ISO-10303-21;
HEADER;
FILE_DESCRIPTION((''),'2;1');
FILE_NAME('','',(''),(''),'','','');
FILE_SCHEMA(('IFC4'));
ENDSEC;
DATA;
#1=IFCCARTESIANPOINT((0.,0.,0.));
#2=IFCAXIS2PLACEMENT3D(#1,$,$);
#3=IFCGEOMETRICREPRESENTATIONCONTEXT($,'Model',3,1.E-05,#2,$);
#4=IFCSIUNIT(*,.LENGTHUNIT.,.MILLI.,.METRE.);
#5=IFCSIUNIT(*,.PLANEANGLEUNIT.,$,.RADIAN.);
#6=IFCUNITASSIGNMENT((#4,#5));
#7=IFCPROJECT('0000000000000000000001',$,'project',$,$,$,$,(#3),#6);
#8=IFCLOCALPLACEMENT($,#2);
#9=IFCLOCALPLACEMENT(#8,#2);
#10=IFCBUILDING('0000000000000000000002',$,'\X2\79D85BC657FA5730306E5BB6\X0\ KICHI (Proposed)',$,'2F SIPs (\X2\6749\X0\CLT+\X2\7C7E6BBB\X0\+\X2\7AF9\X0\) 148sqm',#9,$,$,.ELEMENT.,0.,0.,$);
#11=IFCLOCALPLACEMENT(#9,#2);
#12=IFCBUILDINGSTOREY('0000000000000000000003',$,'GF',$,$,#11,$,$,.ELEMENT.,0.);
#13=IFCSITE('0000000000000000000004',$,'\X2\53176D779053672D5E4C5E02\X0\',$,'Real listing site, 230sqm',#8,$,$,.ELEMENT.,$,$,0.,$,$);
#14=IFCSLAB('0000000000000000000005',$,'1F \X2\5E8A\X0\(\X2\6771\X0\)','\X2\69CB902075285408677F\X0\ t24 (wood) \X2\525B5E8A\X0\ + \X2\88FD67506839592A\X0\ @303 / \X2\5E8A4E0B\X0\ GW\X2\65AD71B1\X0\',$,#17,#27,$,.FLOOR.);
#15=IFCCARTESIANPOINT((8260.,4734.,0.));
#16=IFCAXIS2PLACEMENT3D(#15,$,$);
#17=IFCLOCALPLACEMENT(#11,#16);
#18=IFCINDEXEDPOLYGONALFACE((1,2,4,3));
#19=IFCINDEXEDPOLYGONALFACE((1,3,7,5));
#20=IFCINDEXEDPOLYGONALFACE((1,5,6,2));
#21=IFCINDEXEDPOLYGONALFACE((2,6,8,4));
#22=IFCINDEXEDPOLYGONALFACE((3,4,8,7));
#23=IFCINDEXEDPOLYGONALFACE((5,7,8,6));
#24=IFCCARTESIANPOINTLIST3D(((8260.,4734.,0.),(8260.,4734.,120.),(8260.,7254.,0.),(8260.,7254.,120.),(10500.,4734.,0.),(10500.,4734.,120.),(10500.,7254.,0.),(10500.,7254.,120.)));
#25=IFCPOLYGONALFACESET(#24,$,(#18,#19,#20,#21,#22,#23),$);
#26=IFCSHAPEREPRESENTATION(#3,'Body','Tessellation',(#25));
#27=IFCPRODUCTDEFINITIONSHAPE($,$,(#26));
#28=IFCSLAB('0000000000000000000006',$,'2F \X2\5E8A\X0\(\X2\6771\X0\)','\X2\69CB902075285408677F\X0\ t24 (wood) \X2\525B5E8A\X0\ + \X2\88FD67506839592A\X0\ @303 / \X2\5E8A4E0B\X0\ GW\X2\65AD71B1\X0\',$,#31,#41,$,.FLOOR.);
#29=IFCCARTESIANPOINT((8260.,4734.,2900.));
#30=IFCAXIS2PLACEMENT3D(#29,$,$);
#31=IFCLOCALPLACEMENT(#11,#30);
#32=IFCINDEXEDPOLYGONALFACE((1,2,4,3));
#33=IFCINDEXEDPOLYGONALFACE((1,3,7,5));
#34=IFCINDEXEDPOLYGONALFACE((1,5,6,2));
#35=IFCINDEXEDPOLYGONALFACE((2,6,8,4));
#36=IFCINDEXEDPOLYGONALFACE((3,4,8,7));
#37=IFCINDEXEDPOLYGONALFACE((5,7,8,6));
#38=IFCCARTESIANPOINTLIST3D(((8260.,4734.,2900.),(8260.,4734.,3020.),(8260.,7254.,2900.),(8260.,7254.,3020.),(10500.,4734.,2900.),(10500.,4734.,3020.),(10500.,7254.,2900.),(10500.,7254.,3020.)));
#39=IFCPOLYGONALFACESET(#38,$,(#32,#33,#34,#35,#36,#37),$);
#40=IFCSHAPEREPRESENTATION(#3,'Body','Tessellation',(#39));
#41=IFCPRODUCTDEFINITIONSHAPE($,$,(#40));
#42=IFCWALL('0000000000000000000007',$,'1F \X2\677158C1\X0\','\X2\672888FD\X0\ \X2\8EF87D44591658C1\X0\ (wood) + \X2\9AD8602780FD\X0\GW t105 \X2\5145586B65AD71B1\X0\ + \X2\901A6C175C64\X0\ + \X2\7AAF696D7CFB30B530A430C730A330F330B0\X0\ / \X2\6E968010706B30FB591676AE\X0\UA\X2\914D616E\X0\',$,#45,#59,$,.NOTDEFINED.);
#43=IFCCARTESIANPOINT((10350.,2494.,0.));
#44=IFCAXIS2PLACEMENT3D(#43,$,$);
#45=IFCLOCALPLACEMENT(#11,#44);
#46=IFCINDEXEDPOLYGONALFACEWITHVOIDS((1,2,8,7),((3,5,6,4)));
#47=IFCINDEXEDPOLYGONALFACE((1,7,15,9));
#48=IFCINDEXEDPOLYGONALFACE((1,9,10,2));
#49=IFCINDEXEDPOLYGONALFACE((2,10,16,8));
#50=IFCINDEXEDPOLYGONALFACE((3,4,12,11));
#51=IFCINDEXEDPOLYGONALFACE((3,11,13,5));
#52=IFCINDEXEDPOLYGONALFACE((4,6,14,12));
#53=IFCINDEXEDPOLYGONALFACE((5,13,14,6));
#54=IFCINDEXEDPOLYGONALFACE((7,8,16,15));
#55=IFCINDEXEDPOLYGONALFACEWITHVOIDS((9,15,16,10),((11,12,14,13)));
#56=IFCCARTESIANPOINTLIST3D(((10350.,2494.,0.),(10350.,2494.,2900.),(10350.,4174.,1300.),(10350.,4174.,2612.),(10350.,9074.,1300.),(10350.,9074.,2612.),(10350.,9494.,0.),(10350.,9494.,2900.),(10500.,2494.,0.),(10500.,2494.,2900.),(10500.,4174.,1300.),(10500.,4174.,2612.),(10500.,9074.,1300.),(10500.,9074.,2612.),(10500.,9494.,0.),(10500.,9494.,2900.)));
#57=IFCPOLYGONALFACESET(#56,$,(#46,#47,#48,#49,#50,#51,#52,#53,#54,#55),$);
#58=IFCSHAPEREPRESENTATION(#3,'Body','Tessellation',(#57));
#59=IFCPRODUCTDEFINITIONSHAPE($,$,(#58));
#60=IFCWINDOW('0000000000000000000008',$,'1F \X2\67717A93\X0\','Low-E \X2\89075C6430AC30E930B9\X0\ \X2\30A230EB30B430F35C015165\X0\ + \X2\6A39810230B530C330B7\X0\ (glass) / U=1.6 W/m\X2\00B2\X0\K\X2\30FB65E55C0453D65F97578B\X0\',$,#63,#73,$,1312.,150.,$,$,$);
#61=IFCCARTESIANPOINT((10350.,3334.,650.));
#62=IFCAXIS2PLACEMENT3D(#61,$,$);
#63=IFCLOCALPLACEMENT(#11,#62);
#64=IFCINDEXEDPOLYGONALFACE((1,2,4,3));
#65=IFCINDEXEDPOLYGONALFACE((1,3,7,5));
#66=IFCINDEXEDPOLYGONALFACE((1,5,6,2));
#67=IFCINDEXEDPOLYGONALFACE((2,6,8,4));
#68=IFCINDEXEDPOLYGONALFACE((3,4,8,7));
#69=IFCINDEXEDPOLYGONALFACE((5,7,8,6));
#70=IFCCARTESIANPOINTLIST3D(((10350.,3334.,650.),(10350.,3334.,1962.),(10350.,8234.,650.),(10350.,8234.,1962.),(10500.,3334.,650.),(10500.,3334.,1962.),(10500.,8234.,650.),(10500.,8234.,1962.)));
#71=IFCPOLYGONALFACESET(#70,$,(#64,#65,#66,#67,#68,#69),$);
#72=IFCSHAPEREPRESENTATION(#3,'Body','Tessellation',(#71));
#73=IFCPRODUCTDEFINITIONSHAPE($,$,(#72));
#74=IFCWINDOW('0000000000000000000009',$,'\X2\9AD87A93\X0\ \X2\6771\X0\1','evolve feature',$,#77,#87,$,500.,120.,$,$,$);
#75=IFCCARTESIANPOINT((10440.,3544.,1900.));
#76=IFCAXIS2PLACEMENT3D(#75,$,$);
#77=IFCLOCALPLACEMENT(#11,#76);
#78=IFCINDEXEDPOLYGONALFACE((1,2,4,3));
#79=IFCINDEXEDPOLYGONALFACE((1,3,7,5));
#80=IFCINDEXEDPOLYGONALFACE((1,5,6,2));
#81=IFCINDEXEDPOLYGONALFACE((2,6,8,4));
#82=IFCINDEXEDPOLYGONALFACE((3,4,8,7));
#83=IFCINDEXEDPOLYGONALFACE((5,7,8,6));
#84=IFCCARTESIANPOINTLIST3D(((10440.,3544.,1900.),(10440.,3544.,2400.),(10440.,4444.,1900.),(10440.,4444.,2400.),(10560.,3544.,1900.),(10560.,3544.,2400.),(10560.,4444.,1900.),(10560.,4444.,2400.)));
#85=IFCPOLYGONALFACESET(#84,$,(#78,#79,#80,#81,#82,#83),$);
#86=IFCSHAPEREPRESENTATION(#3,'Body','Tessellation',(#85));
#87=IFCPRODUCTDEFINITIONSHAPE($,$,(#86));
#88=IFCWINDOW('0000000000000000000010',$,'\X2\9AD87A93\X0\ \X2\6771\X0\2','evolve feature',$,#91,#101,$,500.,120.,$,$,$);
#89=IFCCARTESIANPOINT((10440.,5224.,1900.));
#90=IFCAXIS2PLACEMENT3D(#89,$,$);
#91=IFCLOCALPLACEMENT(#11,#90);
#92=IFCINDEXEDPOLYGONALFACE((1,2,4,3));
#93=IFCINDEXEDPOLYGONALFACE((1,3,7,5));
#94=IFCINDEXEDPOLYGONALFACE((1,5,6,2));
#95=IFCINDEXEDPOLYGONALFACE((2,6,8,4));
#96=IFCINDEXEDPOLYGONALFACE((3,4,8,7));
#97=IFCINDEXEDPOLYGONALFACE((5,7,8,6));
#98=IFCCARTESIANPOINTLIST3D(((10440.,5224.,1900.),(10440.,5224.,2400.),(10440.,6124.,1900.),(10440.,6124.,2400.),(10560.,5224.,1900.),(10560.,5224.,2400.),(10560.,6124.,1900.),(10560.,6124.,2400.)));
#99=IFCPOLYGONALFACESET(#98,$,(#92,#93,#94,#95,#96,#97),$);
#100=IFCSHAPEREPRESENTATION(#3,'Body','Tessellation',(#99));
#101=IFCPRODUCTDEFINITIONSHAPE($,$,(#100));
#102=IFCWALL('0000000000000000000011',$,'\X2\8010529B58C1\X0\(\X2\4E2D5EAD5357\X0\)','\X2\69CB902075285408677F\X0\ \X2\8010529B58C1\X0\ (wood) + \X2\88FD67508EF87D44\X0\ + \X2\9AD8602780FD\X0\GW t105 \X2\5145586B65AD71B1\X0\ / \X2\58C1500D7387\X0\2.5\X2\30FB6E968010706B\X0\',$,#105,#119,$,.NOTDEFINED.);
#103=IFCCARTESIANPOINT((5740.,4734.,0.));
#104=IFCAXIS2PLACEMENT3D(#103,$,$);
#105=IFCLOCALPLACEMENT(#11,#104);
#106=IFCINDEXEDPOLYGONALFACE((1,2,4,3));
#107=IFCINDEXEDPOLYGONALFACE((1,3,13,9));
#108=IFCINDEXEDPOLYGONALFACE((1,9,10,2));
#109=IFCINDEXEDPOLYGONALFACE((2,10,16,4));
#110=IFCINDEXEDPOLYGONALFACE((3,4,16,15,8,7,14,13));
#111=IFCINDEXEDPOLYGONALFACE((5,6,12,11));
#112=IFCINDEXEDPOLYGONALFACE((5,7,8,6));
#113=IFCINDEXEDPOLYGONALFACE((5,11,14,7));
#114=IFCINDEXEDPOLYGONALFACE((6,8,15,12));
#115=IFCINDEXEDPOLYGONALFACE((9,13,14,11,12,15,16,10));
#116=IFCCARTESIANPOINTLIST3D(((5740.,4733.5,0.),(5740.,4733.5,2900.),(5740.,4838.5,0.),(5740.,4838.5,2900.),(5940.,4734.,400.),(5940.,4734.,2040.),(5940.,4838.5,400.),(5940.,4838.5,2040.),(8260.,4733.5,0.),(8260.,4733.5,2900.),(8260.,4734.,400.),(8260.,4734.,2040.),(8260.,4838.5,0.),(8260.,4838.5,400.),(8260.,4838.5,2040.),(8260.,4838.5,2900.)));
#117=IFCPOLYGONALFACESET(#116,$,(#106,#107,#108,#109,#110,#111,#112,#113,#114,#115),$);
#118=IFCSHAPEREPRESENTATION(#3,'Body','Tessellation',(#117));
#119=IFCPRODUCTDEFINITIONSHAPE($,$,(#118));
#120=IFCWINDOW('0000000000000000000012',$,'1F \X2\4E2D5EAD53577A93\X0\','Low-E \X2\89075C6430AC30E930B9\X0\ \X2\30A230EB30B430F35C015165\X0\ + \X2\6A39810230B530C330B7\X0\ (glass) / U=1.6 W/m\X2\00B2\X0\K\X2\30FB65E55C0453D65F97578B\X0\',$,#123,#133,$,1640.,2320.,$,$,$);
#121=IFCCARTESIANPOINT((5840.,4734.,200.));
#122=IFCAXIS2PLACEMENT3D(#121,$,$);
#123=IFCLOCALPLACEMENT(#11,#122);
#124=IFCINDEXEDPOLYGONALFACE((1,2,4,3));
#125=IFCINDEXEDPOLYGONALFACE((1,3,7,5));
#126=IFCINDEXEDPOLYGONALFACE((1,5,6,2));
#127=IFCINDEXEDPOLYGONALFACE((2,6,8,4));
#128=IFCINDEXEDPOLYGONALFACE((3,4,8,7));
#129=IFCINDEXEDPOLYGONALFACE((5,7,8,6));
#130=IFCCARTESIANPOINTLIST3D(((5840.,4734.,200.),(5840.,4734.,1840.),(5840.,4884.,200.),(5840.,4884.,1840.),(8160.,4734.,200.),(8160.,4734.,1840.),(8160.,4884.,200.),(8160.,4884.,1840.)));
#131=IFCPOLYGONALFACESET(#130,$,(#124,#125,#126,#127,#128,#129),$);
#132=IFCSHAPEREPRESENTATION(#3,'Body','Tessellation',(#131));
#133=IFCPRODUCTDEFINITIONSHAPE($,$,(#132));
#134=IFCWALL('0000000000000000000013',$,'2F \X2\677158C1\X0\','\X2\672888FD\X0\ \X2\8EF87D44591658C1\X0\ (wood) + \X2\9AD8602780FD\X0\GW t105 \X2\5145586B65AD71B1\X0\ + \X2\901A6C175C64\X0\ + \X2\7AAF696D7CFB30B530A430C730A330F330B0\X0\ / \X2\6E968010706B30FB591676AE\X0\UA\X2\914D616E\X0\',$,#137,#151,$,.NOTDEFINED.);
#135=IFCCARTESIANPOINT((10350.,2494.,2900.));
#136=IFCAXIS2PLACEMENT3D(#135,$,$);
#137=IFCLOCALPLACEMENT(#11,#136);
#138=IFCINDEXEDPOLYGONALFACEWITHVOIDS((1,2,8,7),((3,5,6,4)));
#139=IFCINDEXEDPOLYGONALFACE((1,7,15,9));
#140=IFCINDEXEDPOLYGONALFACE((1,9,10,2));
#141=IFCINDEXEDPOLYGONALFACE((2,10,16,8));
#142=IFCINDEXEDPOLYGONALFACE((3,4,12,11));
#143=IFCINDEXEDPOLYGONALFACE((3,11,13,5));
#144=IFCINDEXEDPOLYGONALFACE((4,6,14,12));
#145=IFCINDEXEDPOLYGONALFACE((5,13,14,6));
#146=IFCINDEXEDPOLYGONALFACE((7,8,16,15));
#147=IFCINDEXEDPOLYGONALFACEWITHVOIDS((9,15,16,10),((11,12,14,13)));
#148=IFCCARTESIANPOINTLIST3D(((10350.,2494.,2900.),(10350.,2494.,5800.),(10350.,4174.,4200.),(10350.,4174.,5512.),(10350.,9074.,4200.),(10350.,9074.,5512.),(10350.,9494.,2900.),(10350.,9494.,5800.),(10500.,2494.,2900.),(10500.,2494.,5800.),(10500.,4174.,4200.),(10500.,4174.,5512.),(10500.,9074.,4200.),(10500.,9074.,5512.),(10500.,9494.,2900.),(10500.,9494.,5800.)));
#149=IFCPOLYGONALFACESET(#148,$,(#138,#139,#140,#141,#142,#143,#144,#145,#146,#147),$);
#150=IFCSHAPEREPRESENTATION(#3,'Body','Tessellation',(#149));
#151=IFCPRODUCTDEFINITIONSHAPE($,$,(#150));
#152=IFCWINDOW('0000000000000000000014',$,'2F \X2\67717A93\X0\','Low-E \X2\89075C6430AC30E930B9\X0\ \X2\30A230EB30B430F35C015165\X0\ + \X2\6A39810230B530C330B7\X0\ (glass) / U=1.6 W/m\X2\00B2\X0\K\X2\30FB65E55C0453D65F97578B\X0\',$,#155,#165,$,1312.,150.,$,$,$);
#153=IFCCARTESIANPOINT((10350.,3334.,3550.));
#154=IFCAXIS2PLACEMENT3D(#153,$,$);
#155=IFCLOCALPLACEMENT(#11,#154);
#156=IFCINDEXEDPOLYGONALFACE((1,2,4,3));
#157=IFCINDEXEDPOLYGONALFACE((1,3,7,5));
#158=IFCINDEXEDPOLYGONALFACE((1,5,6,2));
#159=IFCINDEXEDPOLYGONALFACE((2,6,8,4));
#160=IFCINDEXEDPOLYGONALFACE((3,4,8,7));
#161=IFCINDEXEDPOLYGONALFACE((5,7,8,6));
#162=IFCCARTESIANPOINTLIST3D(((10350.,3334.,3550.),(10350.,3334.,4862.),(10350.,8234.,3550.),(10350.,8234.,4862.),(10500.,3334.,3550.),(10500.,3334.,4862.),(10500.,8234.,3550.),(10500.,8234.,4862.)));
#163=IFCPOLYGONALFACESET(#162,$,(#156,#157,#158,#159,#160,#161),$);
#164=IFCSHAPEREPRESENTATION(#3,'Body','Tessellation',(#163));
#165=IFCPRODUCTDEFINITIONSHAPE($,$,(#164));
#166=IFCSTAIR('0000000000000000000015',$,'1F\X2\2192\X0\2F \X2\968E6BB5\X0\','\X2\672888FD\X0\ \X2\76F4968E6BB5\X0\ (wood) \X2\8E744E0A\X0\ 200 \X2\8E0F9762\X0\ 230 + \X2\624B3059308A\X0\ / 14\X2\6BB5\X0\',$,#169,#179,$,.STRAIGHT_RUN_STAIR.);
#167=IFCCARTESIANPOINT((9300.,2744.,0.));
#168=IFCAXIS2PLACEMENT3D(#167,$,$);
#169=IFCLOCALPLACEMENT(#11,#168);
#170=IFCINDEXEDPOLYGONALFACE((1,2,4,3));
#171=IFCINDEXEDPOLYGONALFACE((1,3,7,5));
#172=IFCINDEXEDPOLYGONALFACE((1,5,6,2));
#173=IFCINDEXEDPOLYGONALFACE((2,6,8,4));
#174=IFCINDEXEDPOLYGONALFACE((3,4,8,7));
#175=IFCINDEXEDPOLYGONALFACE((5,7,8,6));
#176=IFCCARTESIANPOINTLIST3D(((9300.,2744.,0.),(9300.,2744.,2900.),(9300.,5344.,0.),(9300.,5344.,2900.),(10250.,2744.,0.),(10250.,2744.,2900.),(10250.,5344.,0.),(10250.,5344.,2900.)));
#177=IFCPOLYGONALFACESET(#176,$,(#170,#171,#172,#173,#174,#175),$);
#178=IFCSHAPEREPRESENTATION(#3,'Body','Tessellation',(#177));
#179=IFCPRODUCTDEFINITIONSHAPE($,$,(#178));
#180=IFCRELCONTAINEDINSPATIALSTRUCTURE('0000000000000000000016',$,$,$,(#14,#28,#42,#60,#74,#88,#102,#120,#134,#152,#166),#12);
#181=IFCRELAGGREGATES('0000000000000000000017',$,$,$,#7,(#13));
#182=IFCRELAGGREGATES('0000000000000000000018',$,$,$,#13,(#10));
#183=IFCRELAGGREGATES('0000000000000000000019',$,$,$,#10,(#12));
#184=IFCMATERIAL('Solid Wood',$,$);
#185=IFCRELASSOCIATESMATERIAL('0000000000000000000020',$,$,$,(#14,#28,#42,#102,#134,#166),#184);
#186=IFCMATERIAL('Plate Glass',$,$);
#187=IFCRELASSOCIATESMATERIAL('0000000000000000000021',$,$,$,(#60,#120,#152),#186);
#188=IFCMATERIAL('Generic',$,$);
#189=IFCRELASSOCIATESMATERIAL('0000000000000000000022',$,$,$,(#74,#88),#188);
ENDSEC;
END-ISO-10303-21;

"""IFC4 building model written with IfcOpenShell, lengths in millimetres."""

from ifc_helpers import new_model, si_unit, frame, frame_2d, origin, place, context, project, spatial, rectangle, extrude, material, element, fill, save


model = new_model("IFC4")

# Units and contexts
model_context = context("Model", 3, precision=1e-05, world=origin())
ifc_project = project(units=[si_unit("LENGTHUNIT", "METRE", prefix="MILLI"), si_unit("PLANEANGLEUNIT", "RADIAN")], contexts=[model_context])

# Site, building, storey
site_placement = place(None, origin())
site = spatial("IfcSite", under=ifc_project, at=site_placement, Name="北海道札幌市", ObjectType="Real listing site, 230sqm", CompositionType="ELEMENT", RefElevation=0.0)
building_placement = place(site_placement, origin())
building = spatial("IfcBuilding", under=site, at=building_placement, Name="秘密基地の家 KICHI (Proposed)", ObjectType="2F SIPs (杉CLT+籾殻+竹) 148sqm", CompositionType="ELEMENT", ElevationOfRefHeight=0.0, ElevationOfTerrain=0.0)
storey_placement = place(building_placement, origin())
storey = spatial("IfcBuildingStorey", under=building, at=storey_placement, Name="GF", CompositionType="ELEMENT", Elevation=0.0)

# Slabs
ifc_material_1 = material(Name="Solid Wood")
slab_1_placement = place(storey_placement, frame((8260.0, 4734.0, 0.0)))
element("IfcSlab", 1, at=slab_1_placement, inside=storey, material=ifc_material_1, Name="1F 床(東)", Description="構造用合板 t24 (wood) 剛床 + 製材根太 @303 / 床下 GW断熱", PredefinedType="FLOOR", context=model_context, shape_type="SweptSolid", body=[
    extrude(rectangle(XDim=2240.0, YDim=2520.0, at=frame_2d((1120.0, 1260.0))), frame((8260.0, 4734.0, 0.0)), (0.0, 0.0, 1.0), 120.0),
])
slab_2_placement = place(storey_placement, frame((8260.0, 4734.0, 2900.0)))
element("IfcSlab", 2, at=slab_2_placement, inside=storey, material=ifc_material_1, Name="2F 床(東)", Description="構造用合板 t24 (wood) 剛床 + 製材根太 @303 / 床下 GW断熱", PredefinedType="FLOOR", context=model_context, shape_type="SweptSolid", body=[
    extrude(rectangle(XDim=2240.0, YDim=2520.0, at=frame_2d((1120.0, 1260.0))), frame((8260.0, 4734.0, 2900.0)), (0.0, 0.0, 1.0), 120.0),
])

# Wall, openings, windows
wall_1_placement = place(storey_placement, frame((10350.0, 2494.0, 0.0)))
wall_1 = element("IfcWall", 3, at=wall_1_placement, inside=storey, material=ifc_material_1, Name="1F 東壁", Description="木製 軸組外壁 (wood) + 高性能GW t105 充填断熱 + 通気層 + 窯業系サイディング / 準耐火・外皮UA配慮", PredefinedType="NOTDEFINED", context=model_context, shape_type="SweptSolid", body=[
    extrude(rectangle(XDim=150.0, YDim=7000.0, at=frame_2d((75.0, 3500.0))), frame((10350.0, 2494.0, 0.0)), (0.0, 0.0, 1.0), 2900.0),
])
opening_1_placement = place(storey_placement, frame((10350.0, 3334.0, 650.0)))
opening_1 = element("IfcOpeningElement", 4, at=opening_1_placement, cuts=wall_1, PredefinedType="NOTDEFINED", context=model_context, shape_type="SweptSolid", body=[
    extrude(rectangle(XDim=150.0, YDim=4900.0, at=frame_2d((75.0, 2450.0))), frame((10350.0, 3334.0, 650.0)), (0.0, 0.0, 1.0), 1312.0),
])
opening_2_placement = place(storey_placement, frame((10440.0, 3544.0, 1900.0)))
opening_2 = element("IfcOpeningElement", 5, at=opening_2_placement, cuts=wall_1, PredefinedType="NOTDEFINED", context=model_context, shape_type="SweptSolid", body=[
    extrude(rectangle(XDim=120.0, YDim=900.0, at=frame_2d((60.0, 450.0))), frame((10440.0, 3544.0, 1900.0)), (0.0, 0.0, 1.0), 500.0),
])
opening_3_placement = place(storey_placement, frame((10440.0, 5224.0, 1900.0)))
opening_3 = element("IfcOpeningElement", 6, at=opening_3_placement, cuts=wall_1, PredefinedType="NOTDEFINED", context=model_context, shape_type="SweptSolid", body=[
    extrude(rectangle(XDim=120.0, YDim=900.0, at=frame_2d((60.0, 450.0))), frame((10440.0, 5224.0, 1900.0)), (0.0, 0.0, 1.0), 500.0),
])
ifc_material_2 = material(Name="Plate Glass")
window_1_placement = place(storey_placement, frame((10350.0, 3334.0, 650.0)))
window_1 = element("IfcWindow", 7, at=window_1_placement, inside=storey, material=ifc_material_2, Name="1F 東窓", Description="Low-E 複層ガラス アルゴン封入 + 樹脂サッシ (glass) / U=1.6 W/m²K・日射取得型", OverallHeight=1312.0, OverallWidth=150.0, context=model_context, shape_type="SweptSolid", body=[
    extrude(rectangle(XDim=150.0, YDim=4900.0, at=frame_2d((75.0, 2450.0))), frame((10350.0, 3334.0, 650.0)), (0.0, 0.0, 1.0), 1312.0),
])
fill(opening_1, window_1)
ifc_material_3 = material(Name="Generic")
window_2_placement = place(storey_placement, frame((10440.0, 3544.0, 1900.0)))
window_2 = element("IfcWindow", 8, at=window_2_placement, inside=storey, material=ifc_material_3, Name="高窓 東1", Description="evolve feature", OverallHeight=500.0, OverallWidth=120.0, context=model_context, shape_type="SweptSolid", body=[
    extrude(rectangle(XDim=120.0, YDim=900.0, at=frame_2d((60.0, 450.0))), frame((10440.0, 3544.0, 1900.0)), (0.0, 0.0, 1.0), 500.0),
])
fill(opening_2, window_2)
window_3_placement = place(storey_placement, frame((10440.0, 5224.0, 1900.0)))
window_3 = element("IfcWindow", 9, at=window_3_placement, inside=storey, material=ifc_material_3, Name="高窓 東2", Description="evolve feature", OverallHeight=500.0, OverallWidth=120.0, context=model_context, shape_type="SweptSolid", body=[
    extrude(rectangle(XDim=120.0, YDim=900.0, at=frame_2d((60.0, 450.0))), frame((10440.0, 5224.0, 1900.0)), (0.0, 0.0, 1.0), 500.0),
])
fill(opening_3, window_3)

# Wall, opening, window
wall_2_placement = place(storey_placement, frame((5740.0, 4734.0, 0.0)))
wall_2 = element("IfcWall", 10, at=wall_2_placement, inside=storey, material=ifc_material_1, Name="耐力壁(中庭南)", Description="構造用合板 耐力壁 (wood) + 製材軸組 + 高性能GW t105 充填断熱 / 壁倍率2.5・準耐火", PredefinedType="NOTDEFINED", context=model_context, shape_type="SweptSolid", body=[
    extrude(rectangle(XDim=2520.0, YDim=105.0, at=frame_2d((1260.0, 52.0))), frame((5740.0, 4734.0, 0.0)), (0.0, 0.0, 1.0), 2900.0),
])
opening_4_placement = place(storey_placement, frame((5840.0, 4734.0, 200.0)))
opening_4 = element("IfcOpeningElement", 11, at=opening_4_placement, cuts=wall_2, PredefinedType="NOTDEFINED", context=model_context, shape_type="SweptSolid", body=[
    extrude(rectangle(XDim=2320.0, YDim=150.0, at=frame_2d((1160.0, 75.0))), frame((5840.0, 4734.0, 200.0)), (0.0, 0.0, 1.0), 1640.0),
])
window_4_placement = place(storey_placement, frame((5840.0, 4734.0, 200.0)))
window_4 = element("IfcWindow", 12, at=window_4_placement, inside=storey, material=ifc_material_2, Name="1F 中庭南窓", Description="Low-E 複層ガラス アルゴン封入 + 樹脂サッシ (glass) / U=1.6 W/m²K・日射取得型", OverallHeight=1640.0, OverallWidth=2320.0, context=model_context, shape_type="SweptSolid", body=[
    extrude(rectangle(XDim=2320.0, YDim=150.0, at=frame_2d((1160.0, 75.0))), frame((5840.0, 4734.0, 200.0)), (0.0, 0.0, 1.0), 1640.0),
])
fill(opening_4, window_4)

# Wall, opening, window
wall_3_placement = place(storey_placement, frame((10350.0, 2494.0, 2900.0)))
wall_3 = element("IfcWall", 13, at=wall_3_placement, inside=storey, material=ifc_material_1, Name="2F 東壁", Description="木製 軸組外壁 (wood) + 高性能GW t105 充填断熱 + 通気層 + 窯業系サイディング / 準耐火・外皮UA配慮", PredefinedType="NOTDEFINED", context=model_context, shape_type="SweptSolid", body=[
    extrude(rectangle(XDim=150.0, YDim=7000.0, at=frame_2d((75.0, 3500.0))), frame((10350.0, 2494.0, 2900.0)), (0.0, 0.0, 1.0), 2900.0),
])
opening_5_placement = place(storey_placement, frame((10350.0, 3334.0, 3550.0)))
opening_5 = element("IfcOpeningElement", 14, at=opening_5_placement, cuts=wall_3, PredefinedType="NOTDEFINED", context=model_context, shape_type="SweptSolid", body=[
    extrude(rectangle(XDim=150.0, YDim=4900.0, at=frame_2d((75.0, 2450.0))), frame((10350.0, 3334.0, 3550.0)), (0.0, 0.0, 1.0), 1312.0),
])
window_5_placement = place(storey_placement, frame((10350.0, 3334.0, 3550.0)))
window_5 = element("IfcWindow", 15, at=window_5_placement, inside=storey, material=ifc_material_2, Name="2F 東窓", Description="Low-E 複層ガラス アルゴン封入 + 樹脂サッシ (glass) / U=1.6 W/m²K・日射取得型", OverallHeight=1312.0, OverallWidth=150.0, context=model_context, shape_type="SweptSolid", body=[
    extrude(rectangle(XDim=150.0, YDim=4900.0, at=frame_2d((75.0, 2450.0))), frame((10350.0, 3334.0, 3550.0)), (0.0, 0.0, 1.0), 1312.0),
])
fill(opening_5, window_5)

# Stair
stair_placement = place(storey_placement, frame((9300.0, 2744.0, 0.0)))
element("IfcStair", 16, at=stair_placement, inside=storey, material=ifc_material_1, Name="1F→2F 階段", Description="木製 直階段 (wood) 蹴上 200 踏面 230 + 手すり / 14段", PredefinedType="STRAIGHT_RUN_STAIR", context=model_context, shape_type="SweptSolid", body=[
    extrude(rectangle(XDim=950.0, YDim=2600.0, at=frame_2d((475.0, 1300.0))), frame((9300.0, 2744.0, 0.0)), (0.0, 0.0, 1.0), 2900.0),
])

save(model, "model.ifc")
